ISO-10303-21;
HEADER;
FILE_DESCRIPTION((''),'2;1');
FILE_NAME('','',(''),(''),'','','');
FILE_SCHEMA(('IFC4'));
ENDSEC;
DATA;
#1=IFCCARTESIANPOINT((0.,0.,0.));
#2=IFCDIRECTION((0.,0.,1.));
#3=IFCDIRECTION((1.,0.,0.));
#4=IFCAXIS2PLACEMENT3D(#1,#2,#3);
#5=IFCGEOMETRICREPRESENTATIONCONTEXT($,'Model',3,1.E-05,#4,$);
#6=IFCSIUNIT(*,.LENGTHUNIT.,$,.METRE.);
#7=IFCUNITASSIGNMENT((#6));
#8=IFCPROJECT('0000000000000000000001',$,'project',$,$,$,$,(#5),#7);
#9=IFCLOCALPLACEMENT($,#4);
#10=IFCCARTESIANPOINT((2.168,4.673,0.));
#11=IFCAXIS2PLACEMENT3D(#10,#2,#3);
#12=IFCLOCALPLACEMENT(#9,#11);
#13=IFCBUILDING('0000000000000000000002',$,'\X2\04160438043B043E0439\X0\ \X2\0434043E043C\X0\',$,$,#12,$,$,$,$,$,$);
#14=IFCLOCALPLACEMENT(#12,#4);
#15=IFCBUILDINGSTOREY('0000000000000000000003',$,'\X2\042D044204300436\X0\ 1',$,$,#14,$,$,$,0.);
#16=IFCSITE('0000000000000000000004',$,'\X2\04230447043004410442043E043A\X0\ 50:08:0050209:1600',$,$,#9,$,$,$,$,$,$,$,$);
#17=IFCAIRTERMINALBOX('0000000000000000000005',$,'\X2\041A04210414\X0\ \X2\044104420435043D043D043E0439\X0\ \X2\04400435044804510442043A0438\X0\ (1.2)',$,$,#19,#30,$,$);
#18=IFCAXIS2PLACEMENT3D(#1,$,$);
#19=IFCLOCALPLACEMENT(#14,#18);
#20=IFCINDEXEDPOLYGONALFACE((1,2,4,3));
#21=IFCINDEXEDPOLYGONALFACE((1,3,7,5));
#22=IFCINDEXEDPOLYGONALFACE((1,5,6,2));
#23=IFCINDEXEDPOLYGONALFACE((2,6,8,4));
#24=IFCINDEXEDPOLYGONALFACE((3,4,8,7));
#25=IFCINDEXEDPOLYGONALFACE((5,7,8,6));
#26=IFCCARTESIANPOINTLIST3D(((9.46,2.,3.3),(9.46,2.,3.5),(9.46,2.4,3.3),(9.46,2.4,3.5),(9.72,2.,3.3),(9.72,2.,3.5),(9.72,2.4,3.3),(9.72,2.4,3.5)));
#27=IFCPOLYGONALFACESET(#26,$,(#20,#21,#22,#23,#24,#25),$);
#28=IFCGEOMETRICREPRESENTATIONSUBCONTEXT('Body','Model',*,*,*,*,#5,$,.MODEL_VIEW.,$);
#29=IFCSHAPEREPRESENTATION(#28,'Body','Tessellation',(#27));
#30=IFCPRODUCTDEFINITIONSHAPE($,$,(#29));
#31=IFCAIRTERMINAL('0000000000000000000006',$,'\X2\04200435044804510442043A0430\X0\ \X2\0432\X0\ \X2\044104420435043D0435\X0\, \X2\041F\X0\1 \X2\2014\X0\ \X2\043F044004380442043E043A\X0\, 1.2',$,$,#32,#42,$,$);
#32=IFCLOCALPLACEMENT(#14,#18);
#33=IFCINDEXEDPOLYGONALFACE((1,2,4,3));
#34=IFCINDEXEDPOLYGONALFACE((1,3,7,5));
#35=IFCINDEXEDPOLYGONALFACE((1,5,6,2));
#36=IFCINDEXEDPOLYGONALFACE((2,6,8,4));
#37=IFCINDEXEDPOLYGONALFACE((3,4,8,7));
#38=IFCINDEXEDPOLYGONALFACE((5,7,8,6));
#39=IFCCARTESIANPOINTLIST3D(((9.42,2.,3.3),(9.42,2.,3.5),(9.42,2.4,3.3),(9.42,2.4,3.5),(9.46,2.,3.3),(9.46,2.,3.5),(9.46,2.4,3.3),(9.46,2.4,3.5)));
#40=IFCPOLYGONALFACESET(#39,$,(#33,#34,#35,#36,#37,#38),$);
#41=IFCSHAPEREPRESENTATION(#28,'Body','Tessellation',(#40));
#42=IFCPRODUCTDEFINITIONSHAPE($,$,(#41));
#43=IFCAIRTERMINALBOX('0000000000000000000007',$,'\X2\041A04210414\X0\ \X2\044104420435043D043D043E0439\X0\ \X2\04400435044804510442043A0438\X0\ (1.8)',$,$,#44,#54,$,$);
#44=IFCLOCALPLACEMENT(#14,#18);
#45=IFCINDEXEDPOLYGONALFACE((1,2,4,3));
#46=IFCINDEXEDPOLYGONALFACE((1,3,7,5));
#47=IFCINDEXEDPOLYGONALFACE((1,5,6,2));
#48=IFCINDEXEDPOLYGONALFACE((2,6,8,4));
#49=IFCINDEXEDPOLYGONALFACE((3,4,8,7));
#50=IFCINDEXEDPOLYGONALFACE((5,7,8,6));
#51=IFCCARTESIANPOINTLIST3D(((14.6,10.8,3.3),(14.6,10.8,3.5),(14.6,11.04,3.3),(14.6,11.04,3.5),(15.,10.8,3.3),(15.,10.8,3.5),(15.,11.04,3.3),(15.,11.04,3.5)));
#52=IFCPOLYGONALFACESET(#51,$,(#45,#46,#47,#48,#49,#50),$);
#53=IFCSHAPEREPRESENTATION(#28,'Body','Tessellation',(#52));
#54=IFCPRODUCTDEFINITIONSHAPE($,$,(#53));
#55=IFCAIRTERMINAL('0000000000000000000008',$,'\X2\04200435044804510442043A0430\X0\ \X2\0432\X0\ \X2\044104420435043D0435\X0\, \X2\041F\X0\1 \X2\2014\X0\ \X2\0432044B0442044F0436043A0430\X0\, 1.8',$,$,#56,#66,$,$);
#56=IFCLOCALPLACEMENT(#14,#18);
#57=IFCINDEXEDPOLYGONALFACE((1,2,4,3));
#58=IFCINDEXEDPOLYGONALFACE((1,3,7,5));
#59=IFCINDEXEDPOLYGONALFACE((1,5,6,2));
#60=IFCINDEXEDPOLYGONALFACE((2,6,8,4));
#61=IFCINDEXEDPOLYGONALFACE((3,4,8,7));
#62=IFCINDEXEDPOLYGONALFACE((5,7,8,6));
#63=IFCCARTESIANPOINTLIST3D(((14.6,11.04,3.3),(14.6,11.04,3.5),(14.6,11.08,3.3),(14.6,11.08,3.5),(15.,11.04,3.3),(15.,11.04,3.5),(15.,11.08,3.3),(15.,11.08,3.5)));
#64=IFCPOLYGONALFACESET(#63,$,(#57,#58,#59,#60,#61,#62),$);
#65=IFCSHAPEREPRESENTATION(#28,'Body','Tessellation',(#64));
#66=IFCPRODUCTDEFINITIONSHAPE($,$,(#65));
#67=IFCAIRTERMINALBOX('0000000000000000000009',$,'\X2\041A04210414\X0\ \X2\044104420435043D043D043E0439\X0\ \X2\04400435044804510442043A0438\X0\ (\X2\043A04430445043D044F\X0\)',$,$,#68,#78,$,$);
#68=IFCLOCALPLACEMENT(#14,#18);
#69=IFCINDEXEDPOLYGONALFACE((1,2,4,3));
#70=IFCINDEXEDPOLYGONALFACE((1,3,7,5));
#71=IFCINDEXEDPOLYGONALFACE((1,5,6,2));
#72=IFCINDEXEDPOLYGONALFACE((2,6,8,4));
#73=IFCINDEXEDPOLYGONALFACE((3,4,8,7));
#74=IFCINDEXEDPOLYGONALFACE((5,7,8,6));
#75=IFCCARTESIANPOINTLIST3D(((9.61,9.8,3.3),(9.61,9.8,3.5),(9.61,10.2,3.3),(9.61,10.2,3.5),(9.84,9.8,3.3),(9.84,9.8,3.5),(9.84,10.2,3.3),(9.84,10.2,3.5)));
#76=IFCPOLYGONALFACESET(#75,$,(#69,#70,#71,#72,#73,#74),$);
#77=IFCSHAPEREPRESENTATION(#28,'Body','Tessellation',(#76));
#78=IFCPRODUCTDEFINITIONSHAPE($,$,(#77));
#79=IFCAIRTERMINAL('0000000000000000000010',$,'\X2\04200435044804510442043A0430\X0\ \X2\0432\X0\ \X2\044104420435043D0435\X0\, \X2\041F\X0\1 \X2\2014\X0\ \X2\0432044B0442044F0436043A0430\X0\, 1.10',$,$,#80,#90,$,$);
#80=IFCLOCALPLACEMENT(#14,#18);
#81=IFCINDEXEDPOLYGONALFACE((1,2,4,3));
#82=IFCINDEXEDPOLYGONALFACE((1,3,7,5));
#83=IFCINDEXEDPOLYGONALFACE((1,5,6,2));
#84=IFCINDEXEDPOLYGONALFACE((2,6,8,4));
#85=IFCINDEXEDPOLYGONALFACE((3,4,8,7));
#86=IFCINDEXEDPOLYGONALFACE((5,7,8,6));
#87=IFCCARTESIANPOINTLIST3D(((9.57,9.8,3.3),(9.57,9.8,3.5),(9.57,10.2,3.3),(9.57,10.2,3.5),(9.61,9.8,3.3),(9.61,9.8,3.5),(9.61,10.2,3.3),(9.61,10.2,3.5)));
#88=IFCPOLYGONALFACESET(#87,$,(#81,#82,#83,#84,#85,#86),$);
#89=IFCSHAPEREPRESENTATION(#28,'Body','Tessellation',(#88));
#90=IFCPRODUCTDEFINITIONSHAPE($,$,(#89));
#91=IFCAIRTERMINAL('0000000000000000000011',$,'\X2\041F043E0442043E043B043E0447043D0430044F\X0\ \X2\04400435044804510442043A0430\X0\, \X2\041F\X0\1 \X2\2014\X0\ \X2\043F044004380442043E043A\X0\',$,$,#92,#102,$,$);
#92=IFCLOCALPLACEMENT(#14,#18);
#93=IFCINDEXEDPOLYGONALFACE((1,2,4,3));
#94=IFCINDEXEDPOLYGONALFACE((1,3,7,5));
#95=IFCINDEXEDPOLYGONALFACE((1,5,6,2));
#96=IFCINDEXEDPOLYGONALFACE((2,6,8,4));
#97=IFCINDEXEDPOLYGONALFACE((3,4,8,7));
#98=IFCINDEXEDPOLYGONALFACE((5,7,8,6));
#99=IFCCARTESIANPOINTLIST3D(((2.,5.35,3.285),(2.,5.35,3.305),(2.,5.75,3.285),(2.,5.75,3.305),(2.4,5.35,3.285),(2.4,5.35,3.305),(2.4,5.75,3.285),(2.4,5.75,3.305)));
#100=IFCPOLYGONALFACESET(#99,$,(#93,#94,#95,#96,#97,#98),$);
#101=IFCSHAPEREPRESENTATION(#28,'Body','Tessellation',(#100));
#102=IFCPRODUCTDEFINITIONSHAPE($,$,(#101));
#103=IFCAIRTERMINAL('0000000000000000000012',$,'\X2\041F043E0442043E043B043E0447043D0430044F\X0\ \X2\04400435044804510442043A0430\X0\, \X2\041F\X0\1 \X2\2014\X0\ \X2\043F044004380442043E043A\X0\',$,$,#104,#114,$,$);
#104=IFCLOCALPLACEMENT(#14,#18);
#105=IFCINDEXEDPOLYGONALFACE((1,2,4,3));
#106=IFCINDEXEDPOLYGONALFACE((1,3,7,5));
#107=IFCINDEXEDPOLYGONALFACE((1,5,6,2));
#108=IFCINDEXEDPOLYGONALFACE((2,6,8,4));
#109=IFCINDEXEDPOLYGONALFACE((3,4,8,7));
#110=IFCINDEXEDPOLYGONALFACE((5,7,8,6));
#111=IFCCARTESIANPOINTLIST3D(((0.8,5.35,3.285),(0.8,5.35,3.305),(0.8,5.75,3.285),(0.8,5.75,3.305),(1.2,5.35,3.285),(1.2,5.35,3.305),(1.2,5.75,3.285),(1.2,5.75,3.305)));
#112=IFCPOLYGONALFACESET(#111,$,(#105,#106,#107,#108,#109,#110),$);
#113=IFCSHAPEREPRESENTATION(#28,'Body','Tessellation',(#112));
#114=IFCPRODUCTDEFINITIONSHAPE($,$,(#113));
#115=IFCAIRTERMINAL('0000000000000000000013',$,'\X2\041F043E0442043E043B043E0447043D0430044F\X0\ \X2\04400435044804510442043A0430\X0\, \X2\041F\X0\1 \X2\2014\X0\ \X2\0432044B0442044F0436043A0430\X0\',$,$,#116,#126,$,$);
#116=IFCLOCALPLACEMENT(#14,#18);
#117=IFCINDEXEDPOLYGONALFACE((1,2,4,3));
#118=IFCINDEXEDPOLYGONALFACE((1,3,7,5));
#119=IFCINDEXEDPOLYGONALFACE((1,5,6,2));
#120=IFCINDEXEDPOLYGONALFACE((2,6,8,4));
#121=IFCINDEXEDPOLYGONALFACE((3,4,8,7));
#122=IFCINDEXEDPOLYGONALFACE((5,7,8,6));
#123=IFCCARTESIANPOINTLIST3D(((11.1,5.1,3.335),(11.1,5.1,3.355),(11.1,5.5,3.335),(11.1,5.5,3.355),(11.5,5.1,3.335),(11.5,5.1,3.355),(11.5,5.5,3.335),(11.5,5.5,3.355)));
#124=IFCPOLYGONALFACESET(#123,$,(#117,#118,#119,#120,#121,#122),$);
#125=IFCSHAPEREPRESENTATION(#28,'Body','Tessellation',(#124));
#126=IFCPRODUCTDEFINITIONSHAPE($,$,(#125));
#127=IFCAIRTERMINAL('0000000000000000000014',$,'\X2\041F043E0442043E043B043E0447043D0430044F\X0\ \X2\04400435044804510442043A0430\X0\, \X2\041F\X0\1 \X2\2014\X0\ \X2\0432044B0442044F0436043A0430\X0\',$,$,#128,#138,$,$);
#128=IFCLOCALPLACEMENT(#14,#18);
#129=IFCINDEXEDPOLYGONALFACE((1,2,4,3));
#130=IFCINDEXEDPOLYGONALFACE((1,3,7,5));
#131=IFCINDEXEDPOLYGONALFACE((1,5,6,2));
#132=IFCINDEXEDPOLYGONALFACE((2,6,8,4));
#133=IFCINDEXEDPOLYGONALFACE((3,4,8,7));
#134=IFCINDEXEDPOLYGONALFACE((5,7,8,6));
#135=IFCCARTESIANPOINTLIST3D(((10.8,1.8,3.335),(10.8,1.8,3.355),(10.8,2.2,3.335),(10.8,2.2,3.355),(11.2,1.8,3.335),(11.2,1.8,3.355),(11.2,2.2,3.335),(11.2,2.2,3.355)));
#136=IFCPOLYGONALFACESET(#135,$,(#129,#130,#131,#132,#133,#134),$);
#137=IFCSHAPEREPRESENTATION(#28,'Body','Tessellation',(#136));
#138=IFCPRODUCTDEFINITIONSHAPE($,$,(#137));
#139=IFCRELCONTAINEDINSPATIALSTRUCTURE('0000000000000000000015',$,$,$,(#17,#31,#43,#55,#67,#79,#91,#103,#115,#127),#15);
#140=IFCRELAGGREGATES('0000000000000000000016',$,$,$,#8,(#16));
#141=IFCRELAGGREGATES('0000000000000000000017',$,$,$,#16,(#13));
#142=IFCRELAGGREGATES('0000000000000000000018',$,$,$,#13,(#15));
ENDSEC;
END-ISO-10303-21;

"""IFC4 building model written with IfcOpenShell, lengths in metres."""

from ifc_helpers import new_model, si_unit, frame, frame_2d, origin_with_axes, place, context, subcontext, project, spatial, rectangle, extrude, element, save


model = new_model("IFC4")

# Units and contexts
model_context = context("Model", 3, precision=1e-05, world=origin_with_axes())
body_context = subcontext(model_context, "Body", "Model", "MODEL_VIEW")
ifc_project = project(units=[si_unit("LENGTHUNIT", "METRE")], contexts=[model_context])

# Site, building, storey
site_placement = place(None, origin_with_axes())
site = spatial("IfcSite", under=ifc_project, at=site_placement, Name="Участок 50:08:0050209:1600")
building_placement = place(site_placement, frame((2.168, 4.673, 0.0), z_axis=(0.0, 0.0, 1.0), x_axis=(1.0, 0.0, 0.0)))
building = spatial("IfcBuilding", under=site, at=building_placement, Name="Жилой дом")
storey_placement = place(building_placement, origin_with_axes())
storey = spatial("IfcBuildingStorey", under=building, at=storey_placement, Name="Этаж 1", Elevation=0.0)

# Air terminal box
air_terminal_box_1_placement = place(storey_placement, origin_with_axes())
element("IfcAirTerminalBox", 1, at=air_terminal_box_1_placement, inside=storey, Name="КСД стенной решётки (1.2)", context=body_context, shape_type="SweptSolid", body=[
    extrude(rectangle(XDim=0.26, YDim=0.4, at=frame_2d((0.13, 0.2))), frame((9.46, 2.0, 3.3), z_axis=(0.0, 0.0, 1.0), x_axis=(1.0, 0.0, 0.0)), (0.0, 0.0, 1.0), 0.2),
])

# Air terminal
air_terminal_1_placement = place(storey_placement, origin_with_axes())
element("IfcAirTerminal", 2, at=air_terminal_1_placement, inside=storey, Name="Решётка в стене, П1 — приток, 1.2", context=body_context, shape_type="SweptSolid", body=[
    extrude(rectangle(XDim=0.04, YDim=0.4, at=frame_2d((0.02, 0.2))), frame((9.42, 2.0, 3.3), z_axis=(0.0, 0.0, 1.0), x_axis=(1.0, 0.0, 0.0)), (0.0, 0.0, 1.0), 0.2),
])

# Air terminal box
air_terminal_box_2_placement = place(storey_placement, origin_with_axes())
element("IfcAirTerminalBox", 3, at=air_terminal_box_2_placement, inside=storey, Name="КСД стенной решётки (1.8)", context=body_context, shape_type="SweptSolid", body=[
    extrude(rectangle(XDim=0.4, YDim=0.24, at=frame_2d((0.2, 0.12))), frame((14.6, 10.8, 3.3), z_axis=(0.0, 0.0, 1.0), x_axis=(1.0, 0.0, 0.0)), (0.0, 0.0, 1.0), 0.2),
])

# Air terminal
air_terminal_2_placement = place(storey_placement, origin_with_axes())
element("IfcAirTerminal", 4, at=air_terminal_2_placement, inside=storey, Name="Решётка в стене, П1 — вытяжка, 1.8", context=body_context, shape_type="SweptSolid", body=[
    extrude(rectangle(XDim=0.4, YDim=0.04, at=frame_2d((0.2, 0.02))), frame((14.6, 11.04, 3.3), z_axis=(0.0, 0.0, 1.0), x_axis=(1.0, 0.0, 0.0)), (0.0, 0.0, 1.0), 0.2),
])

# Air terminal box
air_terminal_box_3_placement = place(storey_placement, origin_with_axes())
element("IfcAirTerminalBox", 5, at=air_terminal_box_3_placement, inside=storey, Name="КСД стенной решётки (кухня)", context=body_context, shape_type="SweptSolid", body=[
    extrude(rectangle(XDim=0.23, YDim=0.4, at=frame_2d((0.115, 0.2))), frame((9.61, 9.8, 3.3), z_axis=(0.0, 0.0, 1.0), x_axis=(1.0, 0.0, 0.0)), (0.0, 0.0, 1.0), 0.2),
])

# Air terminals
air_terminal_3_placement = place(storey_placement, origin_with_axes())
element("IfcAirTerminal", 6, at=air_terminal_3_placement, inside=storey, Name="Решётка в стене, П1 — вытяжка, 1.10", context=body_context, shape_type="SweptSolid", body=[
    extrude(rectangle(XDim=0.04, YDim=0.4, at=frame_2d((0.02, 0.2))), frame((9.57, 9.8, 3.3), z_axis=(0.0, 0.0, 1.0), x_axis=(1.0, 0.0, 0.0)), (0.0, 0.0, 1.0), 0.2),
])
air_terminal_4_placement = place(storey_placement, origin_with_axes())
element("IfcAirTerminal", 7, at=air_terminal_4_placement, inside=storey, Name="Потолочная решётка, П1 — приток", context=body_context, shape_type="SweptSolid", body=[
    extrude(rectangle(XDim=0.4, YDim=0.4, at=frame_2d((0.2, 0.2))), frame((2.0, 5.35, 3.285), z_axis=(0.0, 0.0, 1.0), x_axis=(1.0, 0.0, 0.0)), (0.0, 0.0, 1.0), 0.02),
])
air_terminal_5_placement = place(storey_placement, origin_with_axes())
element("IfcAirTerminal", 8, at=air_terminal_5_placement, inside=storey, Name="Потолочная решётка, П1 — приток", context=body_context, shape_type="SweptSolid", body=[
    extrude(rectangle(XDim=0.4, YDim=0.4, at=frame_2d((0.2, 0.2))), frame((0.8, 5.35, 3.285), z_axis=(0.0, 0.0, 1.0), x_axis=(1.0, 0.0, 0.0)), (0.0, 0.0, 1.0), 0.02),
])
air_terminal_6_placement = place(storey_placement, origin_with_axes())
element("IfcAirTerminal", 9, at=air_terminal_6_placement, inside=storey, Name="Потолочная решётка, П1 — вытяжка", context=body_context, shape_type="SweptSolid", body=[
    extrude(rectangle(XDim=0.4, YDim=0.4, at=frame_2d((0.2, 0.2))), frame((11.1, 5.1, 3.335), z_axis=(0.0, 0.0, 1.0), x_axis=(1.0, 0.0, 0.0)), (0.0, 0.0, 1.0), 0.02),
])
air_terminal_7_placement = place(storey_placement, origin_with_axes())
element("IfcAirTerminal", 10, at=air_terminal_7_placement, inside=storey, Name="Потолочная решётка, П1 — вытяжка", context=body_context, shape_type="SweptSolid", body=[
    extrude(rectangle(XDim=0.4, YDim=0.4, at=frame_2d((0.2, 0.2))), frame((10.8, 1.8, 3.335), z_axis=(0.0, 0.0, 1.0), x_axis=(1.0, 0.0, 0.0)), (0.0, 0.0, 1.0), 0.02),
])

save(model, "model.ifc")
